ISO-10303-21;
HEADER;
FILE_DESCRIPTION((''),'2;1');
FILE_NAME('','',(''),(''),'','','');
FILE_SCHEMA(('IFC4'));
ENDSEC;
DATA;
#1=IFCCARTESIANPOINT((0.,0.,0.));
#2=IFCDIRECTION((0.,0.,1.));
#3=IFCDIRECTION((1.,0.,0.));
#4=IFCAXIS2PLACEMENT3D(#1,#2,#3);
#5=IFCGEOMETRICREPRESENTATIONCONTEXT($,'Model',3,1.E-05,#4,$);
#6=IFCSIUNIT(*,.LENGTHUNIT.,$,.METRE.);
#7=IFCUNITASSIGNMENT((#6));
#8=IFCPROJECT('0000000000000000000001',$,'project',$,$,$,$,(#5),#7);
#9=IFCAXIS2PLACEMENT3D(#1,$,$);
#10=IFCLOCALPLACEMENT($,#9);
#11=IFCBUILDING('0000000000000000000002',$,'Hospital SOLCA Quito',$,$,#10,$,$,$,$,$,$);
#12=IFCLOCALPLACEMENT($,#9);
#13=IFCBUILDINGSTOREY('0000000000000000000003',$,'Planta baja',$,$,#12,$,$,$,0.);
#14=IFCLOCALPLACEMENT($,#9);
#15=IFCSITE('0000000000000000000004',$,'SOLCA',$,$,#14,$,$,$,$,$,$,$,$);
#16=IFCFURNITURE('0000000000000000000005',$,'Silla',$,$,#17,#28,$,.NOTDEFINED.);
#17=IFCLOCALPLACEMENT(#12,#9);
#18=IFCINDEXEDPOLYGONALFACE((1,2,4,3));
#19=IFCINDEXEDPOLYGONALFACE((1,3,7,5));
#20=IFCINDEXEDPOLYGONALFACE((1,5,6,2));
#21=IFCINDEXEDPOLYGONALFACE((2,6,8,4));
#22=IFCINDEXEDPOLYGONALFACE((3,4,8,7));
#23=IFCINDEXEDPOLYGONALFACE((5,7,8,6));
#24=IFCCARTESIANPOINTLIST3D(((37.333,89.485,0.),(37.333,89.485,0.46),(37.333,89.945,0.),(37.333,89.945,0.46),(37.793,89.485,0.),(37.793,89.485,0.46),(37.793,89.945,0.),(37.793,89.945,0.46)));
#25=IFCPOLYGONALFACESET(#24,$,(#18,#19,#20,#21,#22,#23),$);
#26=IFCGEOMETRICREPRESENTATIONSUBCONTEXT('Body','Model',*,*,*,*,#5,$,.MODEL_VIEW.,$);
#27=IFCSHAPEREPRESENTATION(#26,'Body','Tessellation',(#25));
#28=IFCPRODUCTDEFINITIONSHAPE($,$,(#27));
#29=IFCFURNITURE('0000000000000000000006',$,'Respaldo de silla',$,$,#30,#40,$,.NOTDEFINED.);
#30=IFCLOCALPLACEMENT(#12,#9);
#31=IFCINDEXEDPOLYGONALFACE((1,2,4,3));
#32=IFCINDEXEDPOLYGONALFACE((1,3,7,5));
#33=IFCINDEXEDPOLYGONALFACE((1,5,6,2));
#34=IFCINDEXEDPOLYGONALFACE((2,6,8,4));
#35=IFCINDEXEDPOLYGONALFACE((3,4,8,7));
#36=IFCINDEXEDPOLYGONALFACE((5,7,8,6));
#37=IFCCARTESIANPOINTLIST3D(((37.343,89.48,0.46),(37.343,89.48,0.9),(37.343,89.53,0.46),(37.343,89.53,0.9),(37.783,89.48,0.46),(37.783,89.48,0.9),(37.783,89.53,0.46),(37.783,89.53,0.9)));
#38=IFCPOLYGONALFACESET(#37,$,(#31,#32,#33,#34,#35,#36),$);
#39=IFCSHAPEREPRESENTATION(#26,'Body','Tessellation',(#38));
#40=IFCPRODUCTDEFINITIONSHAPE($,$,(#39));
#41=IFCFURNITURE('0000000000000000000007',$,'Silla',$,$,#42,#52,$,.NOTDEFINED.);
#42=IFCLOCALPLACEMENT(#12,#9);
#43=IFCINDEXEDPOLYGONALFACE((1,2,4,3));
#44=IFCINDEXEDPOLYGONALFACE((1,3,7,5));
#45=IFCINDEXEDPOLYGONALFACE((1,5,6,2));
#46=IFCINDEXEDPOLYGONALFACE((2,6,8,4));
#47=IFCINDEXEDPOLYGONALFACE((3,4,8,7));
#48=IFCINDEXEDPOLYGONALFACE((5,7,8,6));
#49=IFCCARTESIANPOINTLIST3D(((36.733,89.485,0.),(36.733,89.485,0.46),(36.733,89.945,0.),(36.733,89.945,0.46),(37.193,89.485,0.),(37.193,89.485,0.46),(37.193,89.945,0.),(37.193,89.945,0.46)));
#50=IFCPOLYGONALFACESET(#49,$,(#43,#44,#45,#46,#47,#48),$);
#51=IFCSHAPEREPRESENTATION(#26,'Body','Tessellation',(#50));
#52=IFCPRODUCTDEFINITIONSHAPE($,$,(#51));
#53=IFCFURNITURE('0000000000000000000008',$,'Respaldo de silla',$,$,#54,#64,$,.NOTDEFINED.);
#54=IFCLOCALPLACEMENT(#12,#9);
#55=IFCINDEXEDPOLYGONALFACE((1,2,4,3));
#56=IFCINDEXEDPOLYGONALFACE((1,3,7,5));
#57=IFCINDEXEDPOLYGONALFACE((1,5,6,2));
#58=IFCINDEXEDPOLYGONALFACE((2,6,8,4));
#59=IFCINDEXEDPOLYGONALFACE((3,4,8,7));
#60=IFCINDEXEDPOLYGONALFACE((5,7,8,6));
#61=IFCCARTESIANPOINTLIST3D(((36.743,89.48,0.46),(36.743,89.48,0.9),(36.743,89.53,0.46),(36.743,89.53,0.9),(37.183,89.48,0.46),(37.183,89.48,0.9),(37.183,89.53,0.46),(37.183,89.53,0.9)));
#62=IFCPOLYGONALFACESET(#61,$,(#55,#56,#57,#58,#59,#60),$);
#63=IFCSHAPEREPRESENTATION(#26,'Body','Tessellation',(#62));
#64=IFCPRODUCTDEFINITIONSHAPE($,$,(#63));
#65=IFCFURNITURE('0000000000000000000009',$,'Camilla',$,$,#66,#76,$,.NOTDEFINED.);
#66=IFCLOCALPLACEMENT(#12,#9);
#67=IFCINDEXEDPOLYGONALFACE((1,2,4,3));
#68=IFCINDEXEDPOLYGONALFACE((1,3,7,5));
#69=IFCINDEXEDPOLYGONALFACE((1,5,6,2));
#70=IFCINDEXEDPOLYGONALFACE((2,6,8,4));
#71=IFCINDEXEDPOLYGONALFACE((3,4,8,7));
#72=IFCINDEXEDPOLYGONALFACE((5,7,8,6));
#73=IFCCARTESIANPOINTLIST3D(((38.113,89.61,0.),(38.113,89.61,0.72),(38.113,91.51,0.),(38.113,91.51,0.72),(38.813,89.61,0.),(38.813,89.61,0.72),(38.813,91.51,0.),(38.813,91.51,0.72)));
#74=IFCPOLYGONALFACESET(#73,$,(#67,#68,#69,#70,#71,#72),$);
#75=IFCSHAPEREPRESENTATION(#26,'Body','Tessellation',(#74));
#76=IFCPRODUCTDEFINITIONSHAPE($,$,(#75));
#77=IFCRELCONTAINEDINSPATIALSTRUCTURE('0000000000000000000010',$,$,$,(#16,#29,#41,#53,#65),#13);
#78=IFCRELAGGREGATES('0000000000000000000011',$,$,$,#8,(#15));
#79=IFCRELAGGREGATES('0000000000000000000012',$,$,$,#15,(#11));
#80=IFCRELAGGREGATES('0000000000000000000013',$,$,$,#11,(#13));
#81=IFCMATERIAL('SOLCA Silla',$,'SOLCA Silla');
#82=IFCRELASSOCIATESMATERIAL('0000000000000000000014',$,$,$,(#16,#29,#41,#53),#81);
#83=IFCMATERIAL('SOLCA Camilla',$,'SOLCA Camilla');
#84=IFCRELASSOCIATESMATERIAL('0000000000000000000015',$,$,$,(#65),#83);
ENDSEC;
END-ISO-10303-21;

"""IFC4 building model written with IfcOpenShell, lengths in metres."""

from ifc_helpers import new_model, si_unit, frame, origin, origin_with_axes, place, context, subcontext, project, spatial, polyline, outline, extrude, material, element, save


model = new_model("IFC4")

# Units and contexts
model_context = context("Model", 3, precision=1e-05, world=origin_with_axes())
body_context = subcontext(model_context, "Body", "Model", "MODEL_VIEW")
ifc_project = project(units=[si_unit("LENGTHUNIT", "METRE")], contexts=[model_context])

# Site, building, storey
site_placement = place(None, origin())
site = spatial("IfcSite", under=ifc_project, at=site_placement, Name="SOLCA")
building_placement = place(None, origin())
building = spatial("IfcBuilding", under=site, at=building_placement, Name="Hospital SOLCA Quito")
storey_placement = place(None, origin())
storey = spatial("IfcBuildingStorey", under=building, at=storey_placement, Name="Planta baja", Elevation=0.0)

# Furniture
ifc_material_1 = material(Name="SOLCA Silla", Category="SOLCA Silla")
ifc_material_2 = material(Name="SOLCA Camilla", Category="SOLCA Camilla")
furniture_1_placement = place(storey_placement, origin_with_axes())
element("IfcFurniture", 1, at=furniture_1_placement, inside=storey, material=ifc_material_1, Name="Silla", PredefinedType="NOTDEFINED", context=body_context, shape_type="SweptSolid", body=[
    extrude(outline(polyline([(37.793, 89.945), (37.333, 89.945), (37.333, 89.485), (37.793, 89.485), (37.793, 89.945)])), origin_with_axes(), (0.0, 0.0, 1.0), 0.46),
])
furniture_2_placement = place(storey_placement, origin_with_axes())
element("IfcFurniture", 2, at=furniture_2_placement, inside=storey, material=ifc_material_1, Name="Respaldo de silla", PredefinedType="NOTDEFINED", context=body_context, shape_type="SweptSolid", body=[
    extrude(outline(polyline([(37.783, 89.53), (37.343, 89.53), (37.343, 89.48), (37.783, 89.48), (37.783, 89.53)])), frame((0.0, 0.0, 0.46), z_axis=(0.0, 0.0, 1.0), x_axis=(1.0, 0.0, 0.0)), (0.0, 0.0, 1.0), 0.44),
])
furniture_3_placement = place(storey_placement, origin_with_axes())
element("IfcFurniture", 3, at=furniture_3_placement, inside=storey, material=ifc_material_1, Name="Silla", PredefinedType="NOTDEFINED", context=body_context, shape_type="SweptSolid", body=[
    extrude(outline(polyline([(37.193, 89.945), (36.733, 89.945), (36.733, 89.485), (37.193, 89.485), (37.193, 89.945)])), origin_with_axes(), (0.0, 0.0, 1.0), 0.46),
])
furniture_4_placement = place(storey_placement, origin_with_axes())
element("IfcFurniture", 4, at=furniture_4_placement, inside=storey, material=ifc_material_1, Name="Respaldo de silla", PredefinedType="NOTDEFINED", context=body_context, shape_type="SweptSolid", body=[
    extrude(outline(polyline([(37.183, 89.53), (36.743, 89.53), (36.743, 89.48), (37.183, 89.48), (37.183, 89.53)])), frame((0.0, 0.0, 0.46), z_axis=(0.0, 0.0, 1.0), x_axis=(1.0, 0.0, 0.0)), (0.0, 0.0, 1.0), 0.44),
])
furniture_5_placement = place(storey_placement, origin_with_axes())
element("IfcFurniture", 5, at=furniture_5_placement, inside=storey, material=ifc_material_2, Name="Camilla", PredefinedType="NOTDEFINED", context=body_context, shape_type="SweptSolid", body=[
    extrude(outline(polyline([(38.813, 89.61), (38.813, 91.51), (38.113, 91.51), (38.113, 89.61), (38.813, 89.61)])), origin_with_axes(), (0.0, 0.0, 1.0), 0.72),
])

save(model, "model.ifc")
